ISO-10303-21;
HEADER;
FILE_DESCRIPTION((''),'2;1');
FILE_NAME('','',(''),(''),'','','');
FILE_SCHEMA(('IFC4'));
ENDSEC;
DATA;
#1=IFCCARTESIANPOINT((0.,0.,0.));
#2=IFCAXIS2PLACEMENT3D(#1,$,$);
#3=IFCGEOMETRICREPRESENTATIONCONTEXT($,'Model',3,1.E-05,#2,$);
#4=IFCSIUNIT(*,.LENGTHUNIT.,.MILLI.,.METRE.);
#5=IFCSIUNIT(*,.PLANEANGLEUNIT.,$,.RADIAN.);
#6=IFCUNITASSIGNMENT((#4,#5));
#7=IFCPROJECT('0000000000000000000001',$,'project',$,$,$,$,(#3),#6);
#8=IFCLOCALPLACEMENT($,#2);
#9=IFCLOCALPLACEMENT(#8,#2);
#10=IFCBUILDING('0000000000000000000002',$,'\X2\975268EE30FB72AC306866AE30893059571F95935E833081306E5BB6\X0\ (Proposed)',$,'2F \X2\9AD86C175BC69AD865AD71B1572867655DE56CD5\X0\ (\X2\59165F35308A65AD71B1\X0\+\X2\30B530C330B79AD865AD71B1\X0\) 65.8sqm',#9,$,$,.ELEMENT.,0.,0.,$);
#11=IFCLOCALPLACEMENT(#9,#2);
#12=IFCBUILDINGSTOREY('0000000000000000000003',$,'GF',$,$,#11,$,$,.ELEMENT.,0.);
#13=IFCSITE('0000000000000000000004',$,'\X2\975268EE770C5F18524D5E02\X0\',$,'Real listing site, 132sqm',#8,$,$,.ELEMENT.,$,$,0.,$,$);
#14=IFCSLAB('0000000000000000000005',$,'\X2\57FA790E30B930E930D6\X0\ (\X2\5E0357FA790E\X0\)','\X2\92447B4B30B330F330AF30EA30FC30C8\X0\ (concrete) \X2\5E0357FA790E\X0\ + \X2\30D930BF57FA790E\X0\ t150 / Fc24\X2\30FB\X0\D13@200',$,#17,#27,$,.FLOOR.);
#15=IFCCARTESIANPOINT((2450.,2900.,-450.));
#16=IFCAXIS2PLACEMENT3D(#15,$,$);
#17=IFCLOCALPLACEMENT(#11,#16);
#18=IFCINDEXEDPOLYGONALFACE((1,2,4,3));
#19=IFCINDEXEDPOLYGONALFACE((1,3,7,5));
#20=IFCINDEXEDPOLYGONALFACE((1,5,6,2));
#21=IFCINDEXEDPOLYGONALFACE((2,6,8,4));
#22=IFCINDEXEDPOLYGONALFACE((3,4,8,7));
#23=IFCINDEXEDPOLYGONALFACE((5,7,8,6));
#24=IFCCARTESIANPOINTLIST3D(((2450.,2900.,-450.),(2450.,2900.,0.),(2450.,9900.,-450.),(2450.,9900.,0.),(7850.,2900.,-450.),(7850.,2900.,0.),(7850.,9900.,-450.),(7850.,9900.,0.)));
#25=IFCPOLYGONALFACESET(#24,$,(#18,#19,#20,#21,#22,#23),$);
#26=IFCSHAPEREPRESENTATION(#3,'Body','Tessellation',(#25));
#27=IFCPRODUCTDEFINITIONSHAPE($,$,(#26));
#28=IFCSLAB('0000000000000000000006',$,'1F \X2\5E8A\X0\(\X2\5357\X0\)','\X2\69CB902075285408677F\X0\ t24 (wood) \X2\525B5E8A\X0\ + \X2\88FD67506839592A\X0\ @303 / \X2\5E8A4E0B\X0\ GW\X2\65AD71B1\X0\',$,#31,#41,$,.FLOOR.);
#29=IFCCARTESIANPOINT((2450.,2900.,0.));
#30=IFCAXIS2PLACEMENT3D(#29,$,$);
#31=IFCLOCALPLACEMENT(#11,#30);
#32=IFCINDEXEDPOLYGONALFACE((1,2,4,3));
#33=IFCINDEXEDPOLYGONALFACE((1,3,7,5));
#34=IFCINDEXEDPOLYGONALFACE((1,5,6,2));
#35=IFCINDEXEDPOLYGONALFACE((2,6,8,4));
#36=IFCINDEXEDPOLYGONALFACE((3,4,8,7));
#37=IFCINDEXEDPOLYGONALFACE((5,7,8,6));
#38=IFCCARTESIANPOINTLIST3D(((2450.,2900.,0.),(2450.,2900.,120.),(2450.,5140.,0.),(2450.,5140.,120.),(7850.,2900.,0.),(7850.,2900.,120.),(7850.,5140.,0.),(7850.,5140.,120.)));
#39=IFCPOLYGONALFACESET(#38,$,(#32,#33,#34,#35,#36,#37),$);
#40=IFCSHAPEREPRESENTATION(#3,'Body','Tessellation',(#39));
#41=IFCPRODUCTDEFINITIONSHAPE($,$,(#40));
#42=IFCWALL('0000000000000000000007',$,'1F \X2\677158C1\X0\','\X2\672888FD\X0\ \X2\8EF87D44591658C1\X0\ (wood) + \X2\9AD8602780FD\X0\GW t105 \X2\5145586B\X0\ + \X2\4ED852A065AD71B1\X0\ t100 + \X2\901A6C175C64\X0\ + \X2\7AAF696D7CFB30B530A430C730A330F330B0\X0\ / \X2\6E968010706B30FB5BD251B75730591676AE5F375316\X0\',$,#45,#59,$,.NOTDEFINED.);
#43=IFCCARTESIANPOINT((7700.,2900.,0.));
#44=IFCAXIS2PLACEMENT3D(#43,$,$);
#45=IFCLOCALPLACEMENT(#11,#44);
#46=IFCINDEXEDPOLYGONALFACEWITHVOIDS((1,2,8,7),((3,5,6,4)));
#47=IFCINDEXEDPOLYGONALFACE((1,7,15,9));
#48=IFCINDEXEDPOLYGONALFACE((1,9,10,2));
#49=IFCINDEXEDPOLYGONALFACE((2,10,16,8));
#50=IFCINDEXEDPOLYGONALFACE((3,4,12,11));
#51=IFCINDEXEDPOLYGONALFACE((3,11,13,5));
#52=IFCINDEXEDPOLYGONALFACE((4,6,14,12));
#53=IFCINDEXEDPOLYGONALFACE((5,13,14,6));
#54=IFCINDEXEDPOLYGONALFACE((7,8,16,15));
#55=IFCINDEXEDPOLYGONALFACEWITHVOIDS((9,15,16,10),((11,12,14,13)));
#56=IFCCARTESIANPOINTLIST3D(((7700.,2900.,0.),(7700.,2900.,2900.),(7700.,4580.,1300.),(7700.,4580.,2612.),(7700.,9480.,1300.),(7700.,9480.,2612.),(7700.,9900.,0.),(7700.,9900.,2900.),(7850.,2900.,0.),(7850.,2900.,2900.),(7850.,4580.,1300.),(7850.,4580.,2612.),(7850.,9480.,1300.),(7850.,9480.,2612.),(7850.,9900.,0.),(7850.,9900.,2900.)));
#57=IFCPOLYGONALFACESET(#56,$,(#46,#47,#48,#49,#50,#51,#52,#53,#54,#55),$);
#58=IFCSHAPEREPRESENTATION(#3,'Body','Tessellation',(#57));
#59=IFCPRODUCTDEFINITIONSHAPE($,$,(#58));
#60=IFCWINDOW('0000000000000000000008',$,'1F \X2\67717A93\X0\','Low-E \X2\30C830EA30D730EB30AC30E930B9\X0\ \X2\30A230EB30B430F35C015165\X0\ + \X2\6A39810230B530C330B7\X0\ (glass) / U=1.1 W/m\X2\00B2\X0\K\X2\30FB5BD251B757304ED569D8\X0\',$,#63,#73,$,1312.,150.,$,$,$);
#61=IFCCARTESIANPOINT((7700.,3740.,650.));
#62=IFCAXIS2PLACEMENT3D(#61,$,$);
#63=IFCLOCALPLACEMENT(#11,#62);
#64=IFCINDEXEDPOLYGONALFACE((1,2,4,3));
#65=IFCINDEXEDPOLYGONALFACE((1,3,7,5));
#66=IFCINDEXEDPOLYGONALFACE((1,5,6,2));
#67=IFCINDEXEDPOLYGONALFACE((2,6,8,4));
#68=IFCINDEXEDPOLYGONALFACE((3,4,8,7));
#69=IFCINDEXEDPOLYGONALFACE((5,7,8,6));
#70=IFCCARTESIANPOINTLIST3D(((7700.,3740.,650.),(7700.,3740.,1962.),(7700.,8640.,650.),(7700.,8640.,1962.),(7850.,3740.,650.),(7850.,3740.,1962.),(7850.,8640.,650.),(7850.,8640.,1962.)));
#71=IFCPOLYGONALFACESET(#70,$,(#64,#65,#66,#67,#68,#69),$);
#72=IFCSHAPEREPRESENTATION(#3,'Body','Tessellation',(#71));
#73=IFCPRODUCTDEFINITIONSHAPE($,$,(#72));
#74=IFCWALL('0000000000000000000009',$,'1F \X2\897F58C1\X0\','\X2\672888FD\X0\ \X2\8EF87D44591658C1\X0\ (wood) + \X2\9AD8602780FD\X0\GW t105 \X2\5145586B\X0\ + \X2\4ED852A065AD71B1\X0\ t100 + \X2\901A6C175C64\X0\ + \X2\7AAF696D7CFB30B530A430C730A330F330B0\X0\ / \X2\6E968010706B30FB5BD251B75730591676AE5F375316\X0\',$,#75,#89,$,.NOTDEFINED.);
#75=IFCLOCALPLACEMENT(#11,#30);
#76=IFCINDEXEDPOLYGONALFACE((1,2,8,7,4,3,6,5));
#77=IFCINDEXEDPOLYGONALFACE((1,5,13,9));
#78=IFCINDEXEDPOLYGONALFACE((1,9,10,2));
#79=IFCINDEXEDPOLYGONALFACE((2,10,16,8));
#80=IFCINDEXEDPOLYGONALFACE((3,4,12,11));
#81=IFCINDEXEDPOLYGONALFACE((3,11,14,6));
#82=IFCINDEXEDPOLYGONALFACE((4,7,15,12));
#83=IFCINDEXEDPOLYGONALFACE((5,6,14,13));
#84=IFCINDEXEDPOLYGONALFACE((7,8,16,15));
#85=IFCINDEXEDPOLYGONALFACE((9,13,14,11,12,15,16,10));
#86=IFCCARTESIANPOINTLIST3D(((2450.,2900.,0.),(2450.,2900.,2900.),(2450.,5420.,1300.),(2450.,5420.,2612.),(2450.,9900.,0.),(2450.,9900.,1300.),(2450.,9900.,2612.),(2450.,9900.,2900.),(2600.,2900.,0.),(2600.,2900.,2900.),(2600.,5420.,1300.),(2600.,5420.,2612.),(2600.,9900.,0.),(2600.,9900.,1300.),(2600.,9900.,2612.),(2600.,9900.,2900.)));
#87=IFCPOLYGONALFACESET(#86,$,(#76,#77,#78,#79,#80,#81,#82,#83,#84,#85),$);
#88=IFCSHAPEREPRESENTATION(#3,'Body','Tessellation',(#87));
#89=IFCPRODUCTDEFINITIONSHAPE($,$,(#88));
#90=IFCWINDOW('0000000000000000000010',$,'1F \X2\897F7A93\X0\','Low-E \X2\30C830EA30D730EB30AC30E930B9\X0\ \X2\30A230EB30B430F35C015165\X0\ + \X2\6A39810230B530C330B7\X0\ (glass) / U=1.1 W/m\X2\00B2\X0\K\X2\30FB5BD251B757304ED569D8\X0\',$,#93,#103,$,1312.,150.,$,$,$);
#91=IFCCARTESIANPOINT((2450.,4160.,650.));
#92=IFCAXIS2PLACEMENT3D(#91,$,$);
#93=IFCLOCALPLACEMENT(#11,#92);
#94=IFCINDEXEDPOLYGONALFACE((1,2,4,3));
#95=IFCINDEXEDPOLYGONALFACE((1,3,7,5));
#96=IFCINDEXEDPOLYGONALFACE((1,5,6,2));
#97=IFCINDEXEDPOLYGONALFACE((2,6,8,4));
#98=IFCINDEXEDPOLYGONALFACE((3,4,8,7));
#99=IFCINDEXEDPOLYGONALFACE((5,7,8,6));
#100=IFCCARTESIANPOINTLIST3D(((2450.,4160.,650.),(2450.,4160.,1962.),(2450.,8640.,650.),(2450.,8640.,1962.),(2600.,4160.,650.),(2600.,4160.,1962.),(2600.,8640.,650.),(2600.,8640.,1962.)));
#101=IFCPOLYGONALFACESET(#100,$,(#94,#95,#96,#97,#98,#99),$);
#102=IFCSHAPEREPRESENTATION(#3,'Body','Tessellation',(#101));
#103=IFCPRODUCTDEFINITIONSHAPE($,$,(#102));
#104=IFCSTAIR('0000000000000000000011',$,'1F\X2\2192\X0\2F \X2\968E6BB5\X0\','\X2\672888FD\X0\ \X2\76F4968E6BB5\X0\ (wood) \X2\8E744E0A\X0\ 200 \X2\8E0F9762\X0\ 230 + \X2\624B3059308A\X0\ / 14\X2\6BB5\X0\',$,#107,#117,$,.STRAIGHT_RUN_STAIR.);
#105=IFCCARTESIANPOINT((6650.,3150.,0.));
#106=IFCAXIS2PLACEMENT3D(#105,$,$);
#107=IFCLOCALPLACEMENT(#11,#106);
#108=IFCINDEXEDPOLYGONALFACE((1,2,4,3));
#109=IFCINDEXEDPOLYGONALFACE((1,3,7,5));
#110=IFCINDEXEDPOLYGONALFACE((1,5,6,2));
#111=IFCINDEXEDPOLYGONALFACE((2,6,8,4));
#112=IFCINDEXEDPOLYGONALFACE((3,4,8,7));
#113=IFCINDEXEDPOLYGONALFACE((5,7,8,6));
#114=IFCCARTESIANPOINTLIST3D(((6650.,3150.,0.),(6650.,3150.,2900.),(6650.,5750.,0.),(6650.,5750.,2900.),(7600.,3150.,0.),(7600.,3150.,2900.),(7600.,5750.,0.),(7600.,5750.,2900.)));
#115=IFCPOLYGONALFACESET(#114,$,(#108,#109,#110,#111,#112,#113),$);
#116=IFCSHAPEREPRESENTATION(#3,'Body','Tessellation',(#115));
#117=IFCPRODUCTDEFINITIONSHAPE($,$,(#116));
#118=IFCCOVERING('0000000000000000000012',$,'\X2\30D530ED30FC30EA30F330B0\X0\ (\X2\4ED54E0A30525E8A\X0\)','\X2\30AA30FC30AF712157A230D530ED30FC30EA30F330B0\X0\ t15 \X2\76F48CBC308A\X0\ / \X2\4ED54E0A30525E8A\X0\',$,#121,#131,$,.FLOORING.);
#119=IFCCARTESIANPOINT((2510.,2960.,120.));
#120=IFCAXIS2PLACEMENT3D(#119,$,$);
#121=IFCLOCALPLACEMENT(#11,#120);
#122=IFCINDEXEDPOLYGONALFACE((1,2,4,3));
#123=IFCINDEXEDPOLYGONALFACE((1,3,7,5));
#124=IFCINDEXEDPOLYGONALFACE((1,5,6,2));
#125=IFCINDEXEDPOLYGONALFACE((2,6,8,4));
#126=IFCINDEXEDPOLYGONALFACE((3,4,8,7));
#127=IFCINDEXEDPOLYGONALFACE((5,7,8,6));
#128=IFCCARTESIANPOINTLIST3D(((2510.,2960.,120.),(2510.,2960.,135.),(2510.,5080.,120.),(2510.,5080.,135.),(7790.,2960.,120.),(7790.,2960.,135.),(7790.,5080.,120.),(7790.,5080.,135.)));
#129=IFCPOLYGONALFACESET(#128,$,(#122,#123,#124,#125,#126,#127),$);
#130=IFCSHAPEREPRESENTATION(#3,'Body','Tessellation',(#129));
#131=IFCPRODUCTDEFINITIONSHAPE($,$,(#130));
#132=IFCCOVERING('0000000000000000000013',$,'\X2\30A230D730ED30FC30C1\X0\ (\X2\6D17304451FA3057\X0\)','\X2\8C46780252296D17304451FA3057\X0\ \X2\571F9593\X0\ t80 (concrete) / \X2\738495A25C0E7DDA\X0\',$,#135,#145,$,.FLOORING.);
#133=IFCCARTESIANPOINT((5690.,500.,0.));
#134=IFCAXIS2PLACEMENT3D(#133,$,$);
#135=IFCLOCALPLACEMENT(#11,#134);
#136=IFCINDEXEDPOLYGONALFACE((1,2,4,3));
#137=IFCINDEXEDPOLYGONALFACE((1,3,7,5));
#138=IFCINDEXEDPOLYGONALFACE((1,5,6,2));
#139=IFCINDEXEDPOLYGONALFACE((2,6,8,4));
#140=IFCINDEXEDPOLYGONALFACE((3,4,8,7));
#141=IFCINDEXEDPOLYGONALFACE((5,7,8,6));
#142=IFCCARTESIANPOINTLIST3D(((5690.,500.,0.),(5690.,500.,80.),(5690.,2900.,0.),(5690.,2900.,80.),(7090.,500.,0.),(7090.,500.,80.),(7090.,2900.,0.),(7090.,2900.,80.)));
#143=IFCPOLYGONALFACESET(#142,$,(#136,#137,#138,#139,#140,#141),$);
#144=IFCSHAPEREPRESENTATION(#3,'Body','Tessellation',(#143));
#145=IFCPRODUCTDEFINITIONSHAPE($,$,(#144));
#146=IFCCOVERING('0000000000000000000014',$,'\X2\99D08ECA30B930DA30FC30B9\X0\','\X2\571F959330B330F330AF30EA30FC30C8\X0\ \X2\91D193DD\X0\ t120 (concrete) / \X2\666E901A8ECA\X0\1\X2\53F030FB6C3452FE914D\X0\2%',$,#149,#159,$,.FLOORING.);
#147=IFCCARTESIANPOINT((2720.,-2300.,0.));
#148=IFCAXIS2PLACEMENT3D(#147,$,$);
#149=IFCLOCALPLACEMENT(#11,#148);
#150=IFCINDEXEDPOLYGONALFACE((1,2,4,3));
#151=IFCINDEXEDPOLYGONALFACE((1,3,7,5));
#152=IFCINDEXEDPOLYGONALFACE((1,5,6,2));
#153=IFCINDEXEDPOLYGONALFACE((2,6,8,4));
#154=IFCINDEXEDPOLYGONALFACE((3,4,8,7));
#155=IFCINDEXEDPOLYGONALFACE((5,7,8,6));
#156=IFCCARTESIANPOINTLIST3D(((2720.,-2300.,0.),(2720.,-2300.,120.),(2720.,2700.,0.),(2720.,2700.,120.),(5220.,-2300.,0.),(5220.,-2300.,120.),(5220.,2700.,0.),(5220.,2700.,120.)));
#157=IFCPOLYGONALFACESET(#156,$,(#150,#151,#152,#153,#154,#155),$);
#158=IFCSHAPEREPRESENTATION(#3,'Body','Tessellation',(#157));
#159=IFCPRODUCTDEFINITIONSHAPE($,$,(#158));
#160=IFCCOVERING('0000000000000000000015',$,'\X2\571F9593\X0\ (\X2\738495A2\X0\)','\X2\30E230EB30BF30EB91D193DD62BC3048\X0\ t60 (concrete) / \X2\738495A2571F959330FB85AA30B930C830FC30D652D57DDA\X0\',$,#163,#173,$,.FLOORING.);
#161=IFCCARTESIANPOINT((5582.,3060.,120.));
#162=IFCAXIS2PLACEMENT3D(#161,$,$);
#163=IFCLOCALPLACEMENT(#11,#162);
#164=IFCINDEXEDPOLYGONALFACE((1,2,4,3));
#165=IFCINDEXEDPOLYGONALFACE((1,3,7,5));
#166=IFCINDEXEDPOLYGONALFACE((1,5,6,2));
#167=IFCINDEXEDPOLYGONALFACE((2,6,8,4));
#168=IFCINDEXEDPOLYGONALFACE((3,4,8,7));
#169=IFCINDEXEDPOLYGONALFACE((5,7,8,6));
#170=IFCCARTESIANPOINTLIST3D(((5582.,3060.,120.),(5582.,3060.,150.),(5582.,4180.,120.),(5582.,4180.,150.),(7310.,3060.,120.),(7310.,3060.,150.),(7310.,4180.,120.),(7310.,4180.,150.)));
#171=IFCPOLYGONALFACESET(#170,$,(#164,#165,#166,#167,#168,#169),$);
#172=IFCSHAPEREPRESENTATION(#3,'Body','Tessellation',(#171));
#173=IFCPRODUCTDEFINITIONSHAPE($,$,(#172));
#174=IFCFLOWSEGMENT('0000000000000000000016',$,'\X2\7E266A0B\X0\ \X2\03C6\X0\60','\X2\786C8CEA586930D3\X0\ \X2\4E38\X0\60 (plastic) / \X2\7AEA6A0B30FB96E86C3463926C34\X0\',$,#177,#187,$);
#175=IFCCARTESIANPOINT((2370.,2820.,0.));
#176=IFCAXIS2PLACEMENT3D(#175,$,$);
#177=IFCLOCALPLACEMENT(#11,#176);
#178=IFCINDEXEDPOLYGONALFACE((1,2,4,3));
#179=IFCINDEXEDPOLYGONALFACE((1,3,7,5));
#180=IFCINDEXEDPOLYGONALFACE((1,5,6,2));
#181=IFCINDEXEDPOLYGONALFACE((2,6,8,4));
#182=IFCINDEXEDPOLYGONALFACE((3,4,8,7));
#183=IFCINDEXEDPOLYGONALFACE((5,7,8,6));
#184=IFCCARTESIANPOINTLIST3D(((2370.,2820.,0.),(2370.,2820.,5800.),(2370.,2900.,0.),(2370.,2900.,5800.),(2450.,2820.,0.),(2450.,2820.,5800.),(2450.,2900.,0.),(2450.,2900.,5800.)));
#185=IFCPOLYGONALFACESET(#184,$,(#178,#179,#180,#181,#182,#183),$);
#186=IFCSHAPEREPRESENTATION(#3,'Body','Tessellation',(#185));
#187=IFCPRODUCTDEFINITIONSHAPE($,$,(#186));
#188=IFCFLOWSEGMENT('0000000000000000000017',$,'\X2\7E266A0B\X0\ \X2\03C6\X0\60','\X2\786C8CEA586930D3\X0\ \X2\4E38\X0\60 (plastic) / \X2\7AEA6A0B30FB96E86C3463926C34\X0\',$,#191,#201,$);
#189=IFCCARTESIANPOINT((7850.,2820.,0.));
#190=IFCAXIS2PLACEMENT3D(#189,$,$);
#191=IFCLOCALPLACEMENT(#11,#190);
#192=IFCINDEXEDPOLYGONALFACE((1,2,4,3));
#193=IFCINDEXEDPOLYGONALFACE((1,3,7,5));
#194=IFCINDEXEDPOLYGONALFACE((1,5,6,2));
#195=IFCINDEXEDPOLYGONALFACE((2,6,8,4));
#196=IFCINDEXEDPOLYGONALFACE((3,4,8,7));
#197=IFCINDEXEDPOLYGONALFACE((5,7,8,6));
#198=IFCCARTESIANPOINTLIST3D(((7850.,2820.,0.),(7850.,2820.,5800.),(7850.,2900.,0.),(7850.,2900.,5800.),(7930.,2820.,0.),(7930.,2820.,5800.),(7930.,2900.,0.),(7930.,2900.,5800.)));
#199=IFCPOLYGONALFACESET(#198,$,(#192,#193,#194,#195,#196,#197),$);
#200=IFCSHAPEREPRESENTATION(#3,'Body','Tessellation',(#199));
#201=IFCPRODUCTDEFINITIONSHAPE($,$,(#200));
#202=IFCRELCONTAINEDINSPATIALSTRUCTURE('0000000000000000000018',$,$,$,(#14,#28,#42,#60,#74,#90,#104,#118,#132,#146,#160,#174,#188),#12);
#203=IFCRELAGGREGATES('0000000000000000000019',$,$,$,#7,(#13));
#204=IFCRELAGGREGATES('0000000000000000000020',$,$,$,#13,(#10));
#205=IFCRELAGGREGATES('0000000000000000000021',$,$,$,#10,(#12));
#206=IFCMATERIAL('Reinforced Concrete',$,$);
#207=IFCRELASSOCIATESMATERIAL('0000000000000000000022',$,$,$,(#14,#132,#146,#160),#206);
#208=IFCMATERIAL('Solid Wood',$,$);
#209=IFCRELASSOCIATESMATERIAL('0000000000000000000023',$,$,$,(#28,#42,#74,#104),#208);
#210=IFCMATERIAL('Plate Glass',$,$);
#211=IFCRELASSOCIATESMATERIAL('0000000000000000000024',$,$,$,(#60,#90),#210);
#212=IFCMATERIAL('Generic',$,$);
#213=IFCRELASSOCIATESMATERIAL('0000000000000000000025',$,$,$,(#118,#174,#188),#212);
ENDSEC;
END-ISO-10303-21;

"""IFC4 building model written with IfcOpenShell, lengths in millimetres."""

from ifc_helpers import new_model, si_unit, frame, frame_2d, origin, place, context, project, spatial, rectangle, extrude, material, element, fill, save


model = new_model("IFC4")

# Units and contexts
model_context = context("Model", 3, precision=1e-05, world=origin())
ifc_project = project(units=[si_unit("LENGTHUNIT", "METRE", prefix="MILLI"), si_unit("PLANEANGLEUNIT", "RADIAN")], contexts=[model_context])

# Site, building, storey
site_placement = place(None, origin())
site = spatial("IfcSite", under=ifc_project, at=site_placement, Name="青森県弘前市", ObjectType="Real listing site, 132sqm", CompositionType="ELEMENT", RefElevation=0.0)
building_placement = place(site_placement, origin())
building = spatial("IfcBuilding", under=site, at=building_placement, Name="青森・犬と暮らす土間広めの家 (Proposed)", ObjectType="2F 高気密高断熱在来工法 (外張り断熱+サッシ高断熱) 65.8sqm", CompositionType="ELEMENT", ElevationOfRefHeight=0.0, ElevationOfTerrain=0.0)
storey_placement = place(building_placement, origin())
storey = spatial("IfcBuildingStorey", under=building, at=storey_placement, Name="GF", CompositionType="ELEMENT", Elevation=0.0)

# Shared definitions
ifc_material_1 = material(Name="Solid Wood")

# Slabs
ifc_material_2 = material(Name="Reinforced Concrete")
slab_1_placement = place(storey_placement, frame((2450.0, 2900.0, -450.0)))
element("IfcSlab", 1, at=slab_1_placement, inside=storey, material=ifc_material_2, Name="基礎スラブ (布基礎)", Description="鉄筋コンクリート (concrete) 布基礎 + ベタ基礎 t150 / Fc24・D13@200", PredefinedType="FLOOR", context=model_context, shape_type="SweptSolid", body=[
    extrude(rectangle(XDim=5400.0, YDim=7000.0, at=frame_2d((2700.0, 3500.0))), frame((2450.0, 2900.0, -450.0)), (0.0, 0.0, 1.0), 450.0),
])
slab_2_placement = place(storey_placement, frame((2450.0, 2900.0, 0.0)))
element("IfcSlab", 2, at=slab_2_placement, inside=storey, material=ifc_material_1, Name="1F 床(南)", Description="構造用合板 t24 (wood) 剛床 + 製材根太 @303 / 床下 GW断熱", PredefinedType="FLOOR", context=model_context, shape_type="SweptSolid", body=[
    extrude(rectangle(XDim=5400.0, YDim=2240.0, at=frame_2d((2700.0, 1120.0))), frame((2450.0, 2900.0, 0.0)), (0.0, 0.0, 1.0), 120.0),
])

# Shared definitions
ifc_material_3 = material(Name="Plate Glass")

# Walls, openings, windows
wall_1_placement = place(storey_placement, frame((7700.0, 2900.0, 0.0)))
wall_1 = element("IfcWall", 3, at=wall_1_placement, inside=storey, material=ifc_material_1, Name="1F 東壁", Description="木製 軸組外壁 (wood) + 高性能GW t105 充填 + 付加断熱 t100 + 通気層 + 窯業系サイディング / 準耐火・寒冷地外皮強化", PredefinedType="NOTDEFINED", context=model_context, shape_type="SweptSolid", body=[
    extrude(rectangle(XDim=150.0, YDim=7000.0, at=frame_2d((75.0, 3500.0))), frame((7700.0, 2900.0, 0.0)), (0.0, 0.0, 1.0), 2900.0),
])
opening_1_placement = place(storey_placement, frame((7700.0, 3740.0, 650.0)))
opening_1 = element("IfcOpeningElement", 4, at=opening_1_placement, cuts=wall_1, PredefinedType="NOTDEFINED", context=model_context, shape_type="SweptSolid", body=[
    extrude(rectangle(XDim=150.0, YDim=4900.0, at=frame_2d((75.0, 2450.0))), frame((7700.0, 3740.0, 650.0)), (0.0, 0.0, 1.0), 1312.0),
])
window_1_placement = place(storey_placement, frame((7700.0, 3740.0, 650.0)))
window_1 = element("IfcWindow", 5, at=window_1_placement, inside=storey, material=ifc_material_3, Name="1F 東窓", Description="Low-E トリプルガラス アルゴン封入 + 樹脂サッシ (glass) / U=1.1 W/m²K・寒冷地仕様", OverallHeight=1312.0, OverallWidth=150.0, context=model_context, shape_type="SweptSolid", body=[
    extrude(rectangle(XDim=150.0, YDim=4900.0, at=frame_2d((75.0, 2450.0))), frame((7700.0, 3740.0, 650.0)), (0.0, 0.0, 1.0), 1312.0),
])
fill(opening_1, window_1)
wall_2_placement = place(storey_placement, frame((2450.0, 2900.0, 0.0)))
wall_2 = element("IfcWall", 6, at=wall_2_placement, inside=storey, material=ifc_material_1, Name="1F 西壁", Description="木製 軸組外壁 (wood) + 高性能GW t105 充填 + 付加断熱 t100 + 通気層 + 窯業系サイディング / 準耐火・寒冷地外皮強化", PredefinedType="NOTDEFINED", context=model_context, shape_type="SweptSolid", body=[
    extrude(rectangle(XDim=150.0, YDim=7000.0, at=frame_2d((75.0, 3500.0))), frame((2450.0, 2900.0, 0.0)), (0.0, 0.0, 1.0), 2900.0),
])
opening_2_placement = place(storey_placement, frame((2450.0, 4160.0, 650.0)))
opening_2 = element("IfcOpeningElement", 7, at=opening_2_placement, cuts=wall_2, PredefinedType="NOTDEFINED", context=model_context, shape_type="SweptSolid", body=[
    extrude(rectangle(XDim=150.0, YDim=4480.0, at=frame_2d((75.0, 2240.0))), frame((2450.0, 4160.0, 650.0)), (0.0, 0.0, 1.0), 1312.0),
])
window_2_placement = place(storey_placement, frame((2450.0, 4160.0, 650.0)))
window_2 = element("IfcWindow", 8, at=window_2_placement, inside=storey, material=ifc_material_3, Name="1F 西窓", Description="Low-E トリプルガラス アルゴン封入 + 樹脂サッシ (glass) / U=1.1 W/m²K・寒冷地仕様", OverallHeight=1312.0, OverallWidth=150.0, context=model_context, shape_type="SweptSolid", body=[
    extrude(rectangle(XDim=150.0, YDim=4480.0, at=frame_2d((75.0, 2240.0))), frame((2450.0, 4160.0, 650.0)), (0.0, 0.0, 1.0), 1312.0),
])
fill(opening_2, window_2)

# Stair
stair_placement = place(storey_placement, frame((6650.0, 3150.0, 0.0)))
element("IfcStair", 9, at=stair_placement, inside=storey, material=ifc_material_1, Name="1F→2F 階段", Description="木製 直階段 (wood) 蹴上 200 踏面 230 + 手すり / 14段", PredefinedType="STRAIGHT_RUN_STAIR", context=model_context, shape_type="SweptSolid", body=[
    extrude(rectangle(XDim=950.0, YDim=2600.0, at=frame_2d((475.0, 1300.0))), frame((6650.0, 3150.0, 0.0)), (0.0, 0.0, 1.0), 2900.0),
])

# Coverings
ifc_material_4 = material(Name="Generic")
covering_1_placement = place(storey_placement, frame((2510.0, 2960.0, 120.0)))
element("IfcCovering", 10, at=covering_1_placement, inside=storey, material=ifc_material_4, Name="フローリング (仕上げ床)", Description="オーク無垢フローリング t15 直貼り / 仕上げ床", PredefinedType="FLOORING", context=model_context, shape_type="SweptSolid", body=[
    extrude(rectangle(XDim=5280.0, YDim=2120.0, at=frame_2d((2640.0, 1060.0))), frame((2510.0, 2960.0, 120.0)), (0.0, 0.0, 1.0), 15.0),
])
covering_2_placement = place(storey_placement, frame((5690.0, 500.0, 0.0)))
element("IfcCovering", 11, at=covering_2_placement, inside=storey, material=ifc_material_2, Name="アプローチ (洗い出し)", Description="豆砂利洗い出し 土間 t80 (concrete) / 玄関導線", PredefinedType="FLOORING", context=model_context, shape_type="SweptSolid", body=[
    extrude(rectangle(XDim=1400.0, YDim=2400.0, at=frame_2d((700.0, 1200.0))), frame((5690.0, 500.0, 0.0)), (0.0, 0.0, 1.0), 80.0),
])
covering_3_placement = place(storey_placement, frame((2720.0, -2300.0, 0.0)))
element("IfcCovering", 12, at=covering_3_placement, inside=storey, material=ifc_material_2, Name="駐車スペース", Description="土間コンクリート 金鏝 t120 (concrete) / 普通車1台・水勾配2%", PredefinedType="FLOORING", context=model_context, shape_type="SweptSolid", body=[
    extrude(rectangle(XDim=2500.0, YDim=5000.0, at=frame_2d((1250.0, 2500.0))), frame((2720.0, -2300.0, 0.0)), (0.0, 0.0, 1.0), 120.0),
])
covering_4_placement = place(storey_placement, frame((5582.0, 3060.0, 120.0)))
element("IfcCovering", 13, at=covering_4_placement, inside=storey, material=ifc_material_2, Name="土間 (玄関)", Description="モルタル金鏝押え t60 (concrete) / 玄関土間・薪ストーブ動線", PredefinedType="FLOORING", context=model_context, shape_type="SweptSolid", body=[
    extrude(rectangle(XDim=1728.0, YDim=1120.0, at=frame_2d((864.0, 560.0))), frame((5582.0, 3060.0, 120.0)), (0.0, 0.0, 1.0), 30.0),
])

# Flow segments
flow_segment_1_placement = place(storey_placement, frame((2370.0, 2820.0, 0.0)))
element("IfcFlowSegment", 14, at=flow_segment_1_placement, inside=storey, material=ifc_material_4, Name="縦樋 φ60", Description="硬質塩ビ 丸60 (plastic) / 竪樋・雨水排水", context=model_context, shape_type="SweptSolid", body=[
    extrude(rectangle(XDim=80.0, YDim=80.0, at=frame_2d((40.0, 40.0))), frame((2370.0, 2820.0, 0.0)), (0.0, 0.0, 1.0), 5800.0),
])
flow_segment_2_placement = place(storey_placement, frame((7850.0, 2820.0, 0.0)))
element("IfcFlowSegment", 15, at=flow_segment_2_placement, inside=storey, material=ifc_material_4, Name="縦樋 φ60", Description="硬質塩ビ 丸60 (plastic) / 竪樋・雨水排水", context=model_context, shape_type="SweptSolid", body=[
    extrude(rectangle(XDim=80.0, YDim=80.0, at=frame_2d((40.0, 40.0))), frame((7850.0, 2820.0, 0.0)), (0.0, 0.0, 1.0), 5800.0),
])

save(model, "model.ifc")
